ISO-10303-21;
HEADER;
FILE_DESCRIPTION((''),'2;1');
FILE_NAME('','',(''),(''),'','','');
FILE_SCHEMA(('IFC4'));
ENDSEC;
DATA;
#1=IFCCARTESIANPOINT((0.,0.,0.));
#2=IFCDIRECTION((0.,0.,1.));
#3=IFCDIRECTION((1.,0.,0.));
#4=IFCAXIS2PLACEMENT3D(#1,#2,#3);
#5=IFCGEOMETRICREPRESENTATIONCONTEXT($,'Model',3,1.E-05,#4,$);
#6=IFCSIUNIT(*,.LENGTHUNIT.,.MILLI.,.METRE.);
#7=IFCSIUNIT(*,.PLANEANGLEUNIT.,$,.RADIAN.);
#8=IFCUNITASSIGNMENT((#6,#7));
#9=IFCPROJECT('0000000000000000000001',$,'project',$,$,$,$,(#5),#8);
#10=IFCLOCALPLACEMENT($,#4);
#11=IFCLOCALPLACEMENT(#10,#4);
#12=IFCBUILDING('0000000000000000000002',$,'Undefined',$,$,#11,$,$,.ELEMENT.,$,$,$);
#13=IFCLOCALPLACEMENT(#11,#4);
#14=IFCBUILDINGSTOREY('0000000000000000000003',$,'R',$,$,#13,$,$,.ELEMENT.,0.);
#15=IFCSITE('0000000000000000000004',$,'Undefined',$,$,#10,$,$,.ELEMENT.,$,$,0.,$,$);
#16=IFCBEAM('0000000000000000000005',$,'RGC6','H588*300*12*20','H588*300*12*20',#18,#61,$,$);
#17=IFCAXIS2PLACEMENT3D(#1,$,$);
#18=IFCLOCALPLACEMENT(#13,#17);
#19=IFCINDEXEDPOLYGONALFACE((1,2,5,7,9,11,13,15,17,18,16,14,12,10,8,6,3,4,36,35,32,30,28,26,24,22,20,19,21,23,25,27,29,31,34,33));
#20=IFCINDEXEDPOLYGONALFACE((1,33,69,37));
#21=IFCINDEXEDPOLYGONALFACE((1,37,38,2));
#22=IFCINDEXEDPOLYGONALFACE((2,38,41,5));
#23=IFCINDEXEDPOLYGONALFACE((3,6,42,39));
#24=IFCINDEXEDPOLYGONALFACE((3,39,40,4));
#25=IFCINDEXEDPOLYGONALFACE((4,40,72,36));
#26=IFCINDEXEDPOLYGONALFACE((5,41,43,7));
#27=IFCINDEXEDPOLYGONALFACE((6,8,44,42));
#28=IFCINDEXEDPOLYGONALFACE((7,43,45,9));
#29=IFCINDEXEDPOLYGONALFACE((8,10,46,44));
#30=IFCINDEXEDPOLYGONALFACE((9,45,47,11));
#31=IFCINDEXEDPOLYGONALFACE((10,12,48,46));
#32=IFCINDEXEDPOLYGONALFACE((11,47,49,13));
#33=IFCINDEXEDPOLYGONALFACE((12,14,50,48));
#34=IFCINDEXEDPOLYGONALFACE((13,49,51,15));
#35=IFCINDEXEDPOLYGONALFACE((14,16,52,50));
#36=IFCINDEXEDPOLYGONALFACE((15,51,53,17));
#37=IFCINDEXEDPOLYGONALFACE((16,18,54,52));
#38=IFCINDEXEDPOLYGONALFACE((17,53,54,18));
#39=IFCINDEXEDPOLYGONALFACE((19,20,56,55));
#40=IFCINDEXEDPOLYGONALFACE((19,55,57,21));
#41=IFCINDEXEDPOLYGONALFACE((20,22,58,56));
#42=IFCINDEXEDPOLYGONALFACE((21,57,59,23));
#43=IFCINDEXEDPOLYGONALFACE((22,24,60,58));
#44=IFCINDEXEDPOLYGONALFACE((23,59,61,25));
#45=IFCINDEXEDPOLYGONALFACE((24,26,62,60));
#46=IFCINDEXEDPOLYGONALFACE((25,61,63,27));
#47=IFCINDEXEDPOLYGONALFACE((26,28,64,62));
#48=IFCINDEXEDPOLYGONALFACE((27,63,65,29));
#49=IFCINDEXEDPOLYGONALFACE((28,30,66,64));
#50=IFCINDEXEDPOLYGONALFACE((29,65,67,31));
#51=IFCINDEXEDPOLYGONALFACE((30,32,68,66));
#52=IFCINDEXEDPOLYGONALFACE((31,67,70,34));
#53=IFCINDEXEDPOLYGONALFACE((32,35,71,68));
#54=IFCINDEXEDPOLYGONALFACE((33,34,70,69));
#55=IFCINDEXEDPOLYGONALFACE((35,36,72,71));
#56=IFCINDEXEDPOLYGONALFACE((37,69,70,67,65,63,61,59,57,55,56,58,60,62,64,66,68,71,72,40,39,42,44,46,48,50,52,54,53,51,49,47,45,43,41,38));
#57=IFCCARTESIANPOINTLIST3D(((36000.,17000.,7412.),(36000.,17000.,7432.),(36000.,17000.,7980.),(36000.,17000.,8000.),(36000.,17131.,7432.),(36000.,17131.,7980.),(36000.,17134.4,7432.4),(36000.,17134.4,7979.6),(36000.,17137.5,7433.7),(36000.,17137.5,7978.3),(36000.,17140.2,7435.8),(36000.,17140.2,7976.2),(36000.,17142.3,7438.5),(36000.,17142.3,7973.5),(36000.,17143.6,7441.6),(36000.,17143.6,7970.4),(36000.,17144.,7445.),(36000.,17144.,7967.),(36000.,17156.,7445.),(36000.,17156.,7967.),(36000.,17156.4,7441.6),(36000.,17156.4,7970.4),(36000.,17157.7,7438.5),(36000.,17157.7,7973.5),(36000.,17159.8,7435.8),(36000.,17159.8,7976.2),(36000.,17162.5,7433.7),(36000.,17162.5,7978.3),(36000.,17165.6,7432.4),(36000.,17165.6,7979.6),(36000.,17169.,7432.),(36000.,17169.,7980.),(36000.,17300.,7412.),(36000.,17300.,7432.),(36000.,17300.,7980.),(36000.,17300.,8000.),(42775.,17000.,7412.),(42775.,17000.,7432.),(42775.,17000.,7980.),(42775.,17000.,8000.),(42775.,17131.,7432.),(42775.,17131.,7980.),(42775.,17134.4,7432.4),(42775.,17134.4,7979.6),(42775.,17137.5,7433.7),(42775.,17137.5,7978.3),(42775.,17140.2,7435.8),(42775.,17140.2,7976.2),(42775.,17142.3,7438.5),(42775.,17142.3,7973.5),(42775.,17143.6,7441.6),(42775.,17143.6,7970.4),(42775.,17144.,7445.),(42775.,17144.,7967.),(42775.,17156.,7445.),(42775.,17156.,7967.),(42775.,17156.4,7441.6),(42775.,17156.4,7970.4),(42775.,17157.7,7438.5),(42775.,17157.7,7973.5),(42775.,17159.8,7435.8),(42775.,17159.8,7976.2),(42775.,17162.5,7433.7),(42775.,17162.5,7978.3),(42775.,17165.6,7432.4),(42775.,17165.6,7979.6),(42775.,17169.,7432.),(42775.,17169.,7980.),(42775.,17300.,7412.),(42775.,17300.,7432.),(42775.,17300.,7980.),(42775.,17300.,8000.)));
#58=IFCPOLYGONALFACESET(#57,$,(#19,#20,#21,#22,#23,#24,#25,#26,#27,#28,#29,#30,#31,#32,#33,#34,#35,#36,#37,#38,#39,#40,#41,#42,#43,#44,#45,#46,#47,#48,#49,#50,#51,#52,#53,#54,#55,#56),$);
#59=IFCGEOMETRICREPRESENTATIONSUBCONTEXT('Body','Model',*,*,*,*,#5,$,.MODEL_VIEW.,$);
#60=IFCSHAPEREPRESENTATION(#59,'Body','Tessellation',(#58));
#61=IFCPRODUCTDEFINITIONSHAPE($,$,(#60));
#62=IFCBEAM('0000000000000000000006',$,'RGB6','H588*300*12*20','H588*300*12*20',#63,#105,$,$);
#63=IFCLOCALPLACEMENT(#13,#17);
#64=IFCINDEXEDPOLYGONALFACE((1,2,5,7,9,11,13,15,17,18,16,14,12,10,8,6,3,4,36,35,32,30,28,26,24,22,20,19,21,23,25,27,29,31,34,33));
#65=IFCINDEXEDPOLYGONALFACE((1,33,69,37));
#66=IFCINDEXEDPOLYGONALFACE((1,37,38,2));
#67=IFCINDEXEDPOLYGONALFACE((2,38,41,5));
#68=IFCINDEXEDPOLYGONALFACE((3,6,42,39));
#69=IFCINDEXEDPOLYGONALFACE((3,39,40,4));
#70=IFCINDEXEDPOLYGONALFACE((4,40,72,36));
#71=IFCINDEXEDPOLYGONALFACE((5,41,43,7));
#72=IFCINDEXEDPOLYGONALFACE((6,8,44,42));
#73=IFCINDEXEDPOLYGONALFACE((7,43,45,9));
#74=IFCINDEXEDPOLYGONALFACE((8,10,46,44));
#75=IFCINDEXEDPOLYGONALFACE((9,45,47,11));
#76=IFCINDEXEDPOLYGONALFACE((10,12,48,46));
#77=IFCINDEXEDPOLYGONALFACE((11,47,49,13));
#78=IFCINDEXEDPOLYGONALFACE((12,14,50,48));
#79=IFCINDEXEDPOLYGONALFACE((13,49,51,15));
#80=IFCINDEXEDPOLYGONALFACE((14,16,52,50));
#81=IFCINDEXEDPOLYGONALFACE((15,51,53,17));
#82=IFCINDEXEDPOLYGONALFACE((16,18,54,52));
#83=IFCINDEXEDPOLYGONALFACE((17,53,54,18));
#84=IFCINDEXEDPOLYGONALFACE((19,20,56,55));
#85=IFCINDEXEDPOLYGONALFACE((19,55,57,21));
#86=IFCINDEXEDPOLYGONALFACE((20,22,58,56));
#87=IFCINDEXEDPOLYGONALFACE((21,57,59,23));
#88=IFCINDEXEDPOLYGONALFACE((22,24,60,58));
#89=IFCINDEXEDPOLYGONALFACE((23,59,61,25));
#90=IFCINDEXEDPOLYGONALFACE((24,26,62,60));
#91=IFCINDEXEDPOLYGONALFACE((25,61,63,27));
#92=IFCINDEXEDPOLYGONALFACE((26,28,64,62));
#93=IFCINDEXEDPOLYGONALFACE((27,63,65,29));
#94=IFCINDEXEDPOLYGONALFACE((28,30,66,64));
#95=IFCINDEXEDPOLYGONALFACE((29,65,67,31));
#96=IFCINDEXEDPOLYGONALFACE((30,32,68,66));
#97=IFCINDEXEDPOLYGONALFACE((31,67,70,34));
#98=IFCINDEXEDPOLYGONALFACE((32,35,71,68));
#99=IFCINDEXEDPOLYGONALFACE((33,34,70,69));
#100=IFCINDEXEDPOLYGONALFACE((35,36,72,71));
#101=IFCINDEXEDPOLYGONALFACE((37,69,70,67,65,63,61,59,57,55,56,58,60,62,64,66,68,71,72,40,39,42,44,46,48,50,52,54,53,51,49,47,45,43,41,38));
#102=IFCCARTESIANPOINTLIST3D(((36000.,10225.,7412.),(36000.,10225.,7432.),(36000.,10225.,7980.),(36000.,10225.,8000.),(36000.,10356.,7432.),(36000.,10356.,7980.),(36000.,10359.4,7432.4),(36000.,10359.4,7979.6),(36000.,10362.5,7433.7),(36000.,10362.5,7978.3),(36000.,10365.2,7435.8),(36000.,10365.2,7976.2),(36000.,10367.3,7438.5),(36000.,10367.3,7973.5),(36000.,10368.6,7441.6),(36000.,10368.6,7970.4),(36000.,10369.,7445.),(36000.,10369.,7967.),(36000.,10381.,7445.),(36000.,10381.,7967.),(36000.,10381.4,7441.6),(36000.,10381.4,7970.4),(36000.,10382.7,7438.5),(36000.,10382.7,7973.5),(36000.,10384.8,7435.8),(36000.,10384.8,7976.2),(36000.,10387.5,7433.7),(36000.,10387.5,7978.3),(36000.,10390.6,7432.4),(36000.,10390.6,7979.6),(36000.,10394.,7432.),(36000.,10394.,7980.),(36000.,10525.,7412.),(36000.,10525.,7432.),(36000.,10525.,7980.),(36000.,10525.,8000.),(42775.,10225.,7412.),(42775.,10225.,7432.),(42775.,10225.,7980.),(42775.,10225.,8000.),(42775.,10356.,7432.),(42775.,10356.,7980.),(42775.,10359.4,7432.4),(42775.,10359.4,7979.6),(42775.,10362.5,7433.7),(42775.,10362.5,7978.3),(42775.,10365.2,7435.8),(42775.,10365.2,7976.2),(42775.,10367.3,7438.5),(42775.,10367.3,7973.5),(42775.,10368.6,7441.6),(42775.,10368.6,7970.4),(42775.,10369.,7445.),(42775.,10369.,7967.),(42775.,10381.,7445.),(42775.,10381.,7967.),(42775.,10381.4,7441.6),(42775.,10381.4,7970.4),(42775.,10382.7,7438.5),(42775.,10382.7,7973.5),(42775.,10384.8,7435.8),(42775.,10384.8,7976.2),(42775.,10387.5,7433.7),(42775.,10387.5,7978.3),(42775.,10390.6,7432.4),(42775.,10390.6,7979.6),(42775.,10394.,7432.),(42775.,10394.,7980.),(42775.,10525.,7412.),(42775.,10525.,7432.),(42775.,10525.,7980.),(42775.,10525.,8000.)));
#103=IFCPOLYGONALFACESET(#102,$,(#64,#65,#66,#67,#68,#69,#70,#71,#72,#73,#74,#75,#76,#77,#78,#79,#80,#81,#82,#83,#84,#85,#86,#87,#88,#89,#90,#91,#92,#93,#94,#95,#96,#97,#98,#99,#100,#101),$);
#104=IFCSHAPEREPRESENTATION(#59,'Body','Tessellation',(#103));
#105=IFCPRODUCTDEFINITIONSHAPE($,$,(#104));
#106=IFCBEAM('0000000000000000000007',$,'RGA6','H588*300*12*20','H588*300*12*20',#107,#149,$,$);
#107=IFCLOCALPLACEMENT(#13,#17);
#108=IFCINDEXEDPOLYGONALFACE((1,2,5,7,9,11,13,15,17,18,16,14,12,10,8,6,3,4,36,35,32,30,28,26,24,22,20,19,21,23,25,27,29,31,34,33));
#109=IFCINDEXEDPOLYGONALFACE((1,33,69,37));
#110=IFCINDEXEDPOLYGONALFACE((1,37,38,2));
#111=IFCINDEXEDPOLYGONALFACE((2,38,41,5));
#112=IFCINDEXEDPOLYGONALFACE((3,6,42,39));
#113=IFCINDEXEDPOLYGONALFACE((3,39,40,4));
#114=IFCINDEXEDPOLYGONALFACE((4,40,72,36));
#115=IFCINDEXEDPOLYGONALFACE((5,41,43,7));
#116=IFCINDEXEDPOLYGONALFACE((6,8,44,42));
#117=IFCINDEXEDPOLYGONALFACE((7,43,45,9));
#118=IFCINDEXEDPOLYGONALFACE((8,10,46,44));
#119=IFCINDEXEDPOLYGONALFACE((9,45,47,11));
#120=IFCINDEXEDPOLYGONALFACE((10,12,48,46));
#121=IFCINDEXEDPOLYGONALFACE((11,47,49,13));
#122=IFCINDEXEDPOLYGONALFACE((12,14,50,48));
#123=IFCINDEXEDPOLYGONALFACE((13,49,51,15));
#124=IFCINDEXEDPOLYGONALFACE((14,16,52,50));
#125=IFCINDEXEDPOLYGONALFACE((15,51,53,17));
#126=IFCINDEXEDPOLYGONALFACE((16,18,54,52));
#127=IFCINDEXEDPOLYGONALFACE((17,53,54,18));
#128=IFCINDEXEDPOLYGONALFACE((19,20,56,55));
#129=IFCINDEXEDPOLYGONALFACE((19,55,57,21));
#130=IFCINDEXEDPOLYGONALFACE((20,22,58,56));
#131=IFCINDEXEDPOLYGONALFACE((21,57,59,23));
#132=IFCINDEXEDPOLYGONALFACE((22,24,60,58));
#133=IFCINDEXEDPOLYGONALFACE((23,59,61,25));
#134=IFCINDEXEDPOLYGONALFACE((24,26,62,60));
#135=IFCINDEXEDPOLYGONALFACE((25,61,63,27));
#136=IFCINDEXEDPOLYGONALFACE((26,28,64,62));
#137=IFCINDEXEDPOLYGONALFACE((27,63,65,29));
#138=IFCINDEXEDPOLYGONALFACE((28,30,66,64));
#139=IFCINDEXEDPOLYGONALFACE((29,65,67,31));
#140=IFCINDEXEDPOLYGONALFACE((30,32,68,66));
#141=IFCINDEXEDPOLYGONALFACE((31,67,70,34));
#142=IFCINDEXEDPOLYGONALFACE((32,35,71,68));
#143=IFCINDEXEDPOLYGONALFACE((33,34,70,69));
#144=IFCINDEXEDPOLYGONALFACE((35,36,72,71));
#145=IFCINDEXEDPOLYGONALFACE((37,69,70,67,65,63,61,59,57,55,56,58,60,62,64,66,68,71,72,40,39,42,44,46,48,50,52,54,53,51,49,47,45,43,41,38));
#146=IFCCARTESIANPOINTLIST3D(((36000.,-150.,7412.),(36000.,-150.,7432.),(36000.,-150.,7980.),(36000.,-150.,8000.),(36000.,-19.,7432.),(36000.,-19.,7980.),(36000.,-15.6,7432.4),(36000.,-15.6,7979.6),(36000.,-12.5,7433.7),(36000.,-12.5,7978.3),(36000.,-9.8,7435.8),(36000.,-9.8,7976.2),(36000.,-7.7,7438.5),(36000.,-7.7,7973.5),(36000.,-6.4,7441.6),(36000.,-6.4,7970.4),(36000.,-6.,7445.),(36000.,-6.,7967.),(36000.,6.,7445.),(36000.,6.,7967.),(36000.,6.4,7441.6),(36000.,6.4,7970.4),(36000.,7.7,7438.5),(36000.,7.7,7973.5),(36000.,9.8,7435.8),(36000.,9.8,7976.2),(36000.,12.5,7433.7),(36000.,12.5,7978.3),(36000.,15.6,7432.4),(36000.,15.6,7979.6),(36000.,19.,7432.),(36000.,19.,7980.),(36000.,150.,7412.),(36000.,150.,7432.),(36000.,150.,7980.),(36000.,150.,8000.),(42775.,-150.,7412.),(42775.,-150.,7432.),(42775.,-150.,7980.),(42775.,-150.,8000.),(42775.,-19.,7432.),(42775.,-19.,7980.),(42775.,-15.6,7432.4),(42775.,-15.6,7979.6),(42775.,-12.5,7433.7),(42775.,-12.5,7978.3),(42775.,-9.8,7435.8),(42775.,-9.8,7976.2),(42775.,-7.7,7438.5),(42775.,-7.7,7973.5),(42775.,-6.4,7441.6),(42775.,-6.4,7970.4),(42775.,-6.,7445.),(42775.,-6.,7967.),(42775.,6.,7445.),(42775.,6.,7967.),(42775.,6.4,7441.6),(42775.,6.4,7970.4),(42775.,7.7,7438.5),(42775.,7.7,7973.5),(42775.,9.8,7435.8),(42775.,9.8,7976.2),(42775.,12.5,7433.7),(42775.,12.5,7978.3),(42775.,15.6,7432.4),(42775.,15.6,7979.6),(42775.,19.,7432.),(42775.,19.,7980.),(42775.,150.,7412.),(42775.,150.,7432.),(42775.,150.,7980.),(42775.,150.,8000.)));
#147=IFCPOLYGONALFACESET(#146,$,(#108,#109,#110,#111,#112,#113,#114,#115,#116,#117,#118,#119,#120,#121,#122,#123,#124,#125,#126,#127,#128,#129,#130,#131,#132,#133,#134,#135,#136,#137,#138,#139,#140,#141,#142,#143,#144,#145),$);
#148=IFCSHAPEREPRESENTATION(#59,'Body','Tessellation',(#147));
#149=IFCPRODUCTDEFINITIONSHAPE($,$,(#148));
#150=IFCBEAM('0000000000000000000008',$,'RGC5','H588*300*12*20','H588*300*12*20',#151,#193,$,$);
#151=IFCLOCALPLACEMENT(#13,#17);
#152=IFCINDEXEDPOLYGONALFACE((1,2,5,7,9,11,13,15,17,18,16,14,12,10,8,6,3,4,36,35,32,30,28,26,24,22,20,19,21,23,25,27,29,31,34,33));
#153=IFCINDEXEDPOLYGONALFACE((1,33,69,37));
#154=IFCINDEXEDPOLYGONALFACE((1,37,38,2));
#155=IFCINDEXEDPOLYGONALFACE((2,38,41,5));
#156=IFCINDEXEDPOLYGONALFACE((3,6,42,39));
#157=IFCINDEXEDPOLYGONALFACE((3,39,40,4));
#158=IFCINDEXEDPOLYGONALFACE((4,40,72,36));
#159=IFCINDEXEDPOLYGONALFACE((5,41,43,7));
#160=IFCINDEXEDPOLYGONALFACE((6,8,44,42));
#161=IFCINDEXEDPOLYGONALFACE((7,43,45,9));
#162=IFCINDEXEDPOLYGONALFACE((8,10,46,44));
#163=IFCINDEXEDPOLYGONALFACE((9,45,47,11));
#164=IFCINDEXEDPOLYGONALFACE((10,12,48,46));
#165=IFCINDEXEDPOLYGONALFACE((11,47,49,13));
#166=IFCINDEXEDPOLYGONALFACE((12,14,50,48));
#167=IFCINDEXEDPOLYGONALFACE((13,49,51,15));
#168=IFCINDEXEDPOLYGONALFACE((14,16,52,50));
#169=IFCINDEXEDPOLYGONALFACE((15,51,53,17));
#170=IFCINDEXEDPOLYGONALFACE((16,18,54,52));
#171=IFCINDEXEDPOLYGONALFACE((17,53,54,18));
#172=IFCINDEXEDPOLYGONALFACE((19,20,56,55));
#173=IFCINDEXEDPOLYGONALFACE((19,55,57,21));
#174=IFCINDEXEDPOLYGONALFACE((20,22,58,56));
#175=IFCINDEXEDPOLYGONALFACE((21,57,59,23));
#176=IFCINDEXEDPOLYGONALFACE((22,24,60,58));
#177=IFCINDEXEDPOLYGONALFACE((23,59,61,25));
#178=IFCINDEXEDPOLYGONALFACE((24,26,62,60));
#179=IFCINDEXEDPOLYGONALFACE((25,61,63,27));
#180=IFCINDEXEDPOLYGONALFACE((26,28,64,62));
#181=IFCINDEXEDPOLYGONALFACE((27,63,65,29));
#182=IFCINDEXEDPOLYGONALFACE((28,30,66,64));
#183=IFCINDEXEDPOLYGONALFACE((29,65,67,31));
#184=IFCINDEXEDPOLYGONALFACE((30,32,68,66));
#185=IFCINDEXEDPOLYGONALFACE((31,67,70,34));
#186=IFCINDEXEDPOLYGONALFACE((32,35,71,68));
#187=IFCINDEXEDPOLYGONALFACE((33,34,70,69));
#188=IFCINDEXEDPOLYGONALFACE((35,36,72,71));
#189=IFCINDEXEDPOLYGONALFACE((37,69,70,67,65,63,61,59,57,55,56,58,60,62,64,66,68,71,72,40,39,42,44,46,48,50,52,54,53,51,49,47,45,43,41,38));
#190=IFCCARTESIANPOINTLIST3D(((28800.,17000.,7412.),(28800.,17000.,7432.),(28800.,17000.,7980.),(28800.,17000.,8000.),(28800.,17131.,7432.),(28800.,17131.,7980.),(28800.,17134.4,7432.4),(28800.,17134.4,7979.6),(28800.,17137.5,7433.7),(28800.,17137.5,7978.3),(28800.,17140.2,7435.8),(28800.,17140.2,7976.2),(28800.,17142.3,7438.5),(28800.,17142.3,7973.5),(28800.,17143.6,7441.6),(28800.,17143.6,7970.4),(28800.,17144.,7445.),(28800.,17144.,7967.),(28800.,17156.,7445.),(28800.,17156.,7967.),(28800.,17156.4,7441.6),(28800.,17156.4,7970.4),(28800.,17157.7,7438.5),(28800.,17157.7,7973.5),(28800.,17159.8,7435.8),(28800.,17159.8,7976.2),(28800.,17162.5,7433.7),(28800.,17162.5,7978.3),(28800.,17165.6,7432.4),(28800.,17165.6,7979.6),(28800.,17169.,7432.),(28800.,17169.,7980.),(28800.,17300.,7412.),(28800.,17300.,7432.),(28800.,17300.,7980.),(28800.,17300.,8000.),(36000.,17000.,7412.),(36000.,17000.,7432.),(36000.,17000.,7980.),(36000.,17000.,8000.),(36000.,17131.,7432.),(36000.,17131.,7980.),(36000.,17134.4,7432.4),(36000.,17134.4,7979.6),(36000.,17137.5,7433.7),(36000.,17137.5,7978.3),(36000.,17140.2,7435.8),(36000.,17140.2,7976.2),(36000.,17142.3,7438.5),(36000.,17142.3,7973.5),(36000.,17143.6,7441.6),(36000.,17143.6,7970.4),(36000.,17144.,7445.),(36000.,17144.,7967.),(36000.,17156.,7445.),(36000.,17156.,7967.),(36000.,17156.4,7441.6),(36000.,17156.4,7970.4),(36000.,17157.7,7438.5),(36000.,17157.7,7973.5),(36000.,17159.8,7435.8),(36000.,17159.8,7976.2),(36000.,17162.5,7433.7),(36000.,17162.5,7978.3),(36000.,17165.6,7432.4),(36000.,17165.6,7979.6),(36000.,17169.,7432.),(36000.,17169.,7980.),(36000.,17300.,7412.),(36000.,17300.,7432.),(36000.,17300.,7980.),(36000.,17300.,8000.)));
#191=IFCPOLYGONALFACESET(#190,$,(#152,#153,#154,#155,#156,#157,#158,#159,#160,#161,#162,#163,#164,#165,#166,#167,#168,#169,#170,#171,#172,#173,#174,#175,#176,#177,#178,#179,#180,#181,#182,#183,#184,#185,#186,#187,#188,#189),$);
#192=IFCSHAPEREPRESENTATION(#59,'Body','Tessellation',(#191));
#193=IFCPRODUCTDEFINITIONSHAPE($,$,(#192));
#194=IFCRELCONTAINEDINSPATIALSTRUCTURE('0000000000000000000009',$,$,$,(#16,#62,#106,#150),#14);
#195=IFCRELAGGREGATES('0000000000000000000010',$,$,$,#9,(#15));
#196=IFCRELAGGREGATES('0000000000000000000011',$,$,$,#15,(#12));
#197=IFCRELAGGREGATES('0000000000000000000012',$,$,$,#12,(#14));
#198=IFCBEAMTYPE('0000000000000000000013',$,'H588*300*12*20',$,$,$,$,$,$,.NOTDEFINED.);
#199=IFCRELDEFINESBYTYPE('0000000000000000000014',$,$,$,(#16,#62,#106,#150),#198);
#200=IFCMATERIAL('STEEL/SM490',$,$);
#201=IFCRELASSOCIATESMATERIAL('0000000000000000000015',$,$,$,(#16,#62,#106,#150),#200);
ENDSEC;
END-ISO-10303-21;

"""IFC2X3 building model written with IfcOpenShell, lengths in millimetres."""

from ifc_helpers import new_model, si_unit, frame, origin_with_axes, origin_2d_with_axis, place, context, subcontext, project, spatial, i_section, extrude, material, type_object, element, save


model = new_model("IFC2X3")

# Units and contexts
model_context = context("Model", 3, precision=1e-05, world=origin_with_axes())
body_context = subcontext(model_context, "Body", "Model", "MODEL_VIEW")
ifc_project = project(units=[si_unit("LENGTHUNIT", "METRE", prefix="MILLI"), si_unit("PLANEANGLEUNIT", "RADIAN")], contexts=[model_context])

# Site, building, storey
site_placement = place(None, origin_with_axes())
site = spatial("IfcSite", under=ifc_project, at=site_placement, Name="Undefined", CompositionType="ELEMENT", RefElevation=0.0)
building_placement = place(site_placement, origin_with_axes())
building = spatial("IfcBuilding", under=site, at=building_placement, Name="Undefined", CompositionType="ELEMENT")
storey_placement = place(building_placement, origin_with_axes())
storey = spatial("IfcBuildingStorey", under=building, at=storey_placement, Name="R", CompositionType="ELEMENT", Elevation=0.0)

# Beams
ifc_material_1 = material(Name="STEEL/SM490")
beam_type_1 = type_object("IfcBeamType", Name="H588*300*12*20", PredefinedType="NOTDEFINED")
for number, where, z_axis, x_axis, name in (
    (1, (36000.0, 17150.0, 7706.0), (0.0, 0.0, 1.0), (1.0, 0.0, 0.0), "RGC6"),
    (2, (36000.0, 10375.0, 7706.0), (0.0, 0.0, 1.0), (1.0, 0.0, 0.0), "RGB6"),
    (3, (36000.0, 0.0, 7706.0), (0.0, 0.0, 1.0), (1.0, 0.0, 0.0), "RGA6"),
):
    element("IfcBeam", number, at=place(storey_placement, frame(where, z_axis=z_axis, x_axis=x_axis)), inside=storey, type_object=beam_type_1, material=ifc_material_1, Name=name, Description="H588*300*12*20", ObjectType="H588*300*12*20", context=body_context, shape_type="SweptSolid", body=[
        extrude(i_section(OverallWidth=300.0, OverallDepth=588.0, WebThickness=12.0, FlangeThickness=20.0, FilletRadius=13.0, at=origin_2d_with_axis()), frame((6775.0, 0.0, 0.0), z_axis=(-1.0, 0.0, 0.0), x_axis=(0.0, -1.0, 0.0)), (0.0, 0.0, 1.0), 6775.0),
    ])
for number, where, z_axis, x_axis, name in (
    (4, (28800.0, 17150.0, 7706.0), (0.0, 0.0, 1.0), (1.0, 0.0, 0.0), "RGC5"),
):
    element("IfcBeam", number, at=place(storey_placement, frame(where, z_axis=z_axis, x_axis=x_axis)), inside=storey, type_object=beam_type_1, material=ifc_material_1, Name=name, Description="H588*300*12*20", ObjectType="H588*300*12*20", context=body_context, shape_type="SweptSolid", body=[
        extrude(i_section(OverallWidth=300.0, OverallDepth=588.0, WebThickness=12.0, FlangeThickness=20.0, FilletRadius=13.0, at=origin_2d_with_axis()), frame((7200.0, 0.0, 0.0), z_axis=(-1.0, 0.0, 0.0), x_axis=(0.0, -1.0, 0.0)), (0.0, 0.0, 1.0), 7200.0),
    ])

save(model, "model.ifc")
